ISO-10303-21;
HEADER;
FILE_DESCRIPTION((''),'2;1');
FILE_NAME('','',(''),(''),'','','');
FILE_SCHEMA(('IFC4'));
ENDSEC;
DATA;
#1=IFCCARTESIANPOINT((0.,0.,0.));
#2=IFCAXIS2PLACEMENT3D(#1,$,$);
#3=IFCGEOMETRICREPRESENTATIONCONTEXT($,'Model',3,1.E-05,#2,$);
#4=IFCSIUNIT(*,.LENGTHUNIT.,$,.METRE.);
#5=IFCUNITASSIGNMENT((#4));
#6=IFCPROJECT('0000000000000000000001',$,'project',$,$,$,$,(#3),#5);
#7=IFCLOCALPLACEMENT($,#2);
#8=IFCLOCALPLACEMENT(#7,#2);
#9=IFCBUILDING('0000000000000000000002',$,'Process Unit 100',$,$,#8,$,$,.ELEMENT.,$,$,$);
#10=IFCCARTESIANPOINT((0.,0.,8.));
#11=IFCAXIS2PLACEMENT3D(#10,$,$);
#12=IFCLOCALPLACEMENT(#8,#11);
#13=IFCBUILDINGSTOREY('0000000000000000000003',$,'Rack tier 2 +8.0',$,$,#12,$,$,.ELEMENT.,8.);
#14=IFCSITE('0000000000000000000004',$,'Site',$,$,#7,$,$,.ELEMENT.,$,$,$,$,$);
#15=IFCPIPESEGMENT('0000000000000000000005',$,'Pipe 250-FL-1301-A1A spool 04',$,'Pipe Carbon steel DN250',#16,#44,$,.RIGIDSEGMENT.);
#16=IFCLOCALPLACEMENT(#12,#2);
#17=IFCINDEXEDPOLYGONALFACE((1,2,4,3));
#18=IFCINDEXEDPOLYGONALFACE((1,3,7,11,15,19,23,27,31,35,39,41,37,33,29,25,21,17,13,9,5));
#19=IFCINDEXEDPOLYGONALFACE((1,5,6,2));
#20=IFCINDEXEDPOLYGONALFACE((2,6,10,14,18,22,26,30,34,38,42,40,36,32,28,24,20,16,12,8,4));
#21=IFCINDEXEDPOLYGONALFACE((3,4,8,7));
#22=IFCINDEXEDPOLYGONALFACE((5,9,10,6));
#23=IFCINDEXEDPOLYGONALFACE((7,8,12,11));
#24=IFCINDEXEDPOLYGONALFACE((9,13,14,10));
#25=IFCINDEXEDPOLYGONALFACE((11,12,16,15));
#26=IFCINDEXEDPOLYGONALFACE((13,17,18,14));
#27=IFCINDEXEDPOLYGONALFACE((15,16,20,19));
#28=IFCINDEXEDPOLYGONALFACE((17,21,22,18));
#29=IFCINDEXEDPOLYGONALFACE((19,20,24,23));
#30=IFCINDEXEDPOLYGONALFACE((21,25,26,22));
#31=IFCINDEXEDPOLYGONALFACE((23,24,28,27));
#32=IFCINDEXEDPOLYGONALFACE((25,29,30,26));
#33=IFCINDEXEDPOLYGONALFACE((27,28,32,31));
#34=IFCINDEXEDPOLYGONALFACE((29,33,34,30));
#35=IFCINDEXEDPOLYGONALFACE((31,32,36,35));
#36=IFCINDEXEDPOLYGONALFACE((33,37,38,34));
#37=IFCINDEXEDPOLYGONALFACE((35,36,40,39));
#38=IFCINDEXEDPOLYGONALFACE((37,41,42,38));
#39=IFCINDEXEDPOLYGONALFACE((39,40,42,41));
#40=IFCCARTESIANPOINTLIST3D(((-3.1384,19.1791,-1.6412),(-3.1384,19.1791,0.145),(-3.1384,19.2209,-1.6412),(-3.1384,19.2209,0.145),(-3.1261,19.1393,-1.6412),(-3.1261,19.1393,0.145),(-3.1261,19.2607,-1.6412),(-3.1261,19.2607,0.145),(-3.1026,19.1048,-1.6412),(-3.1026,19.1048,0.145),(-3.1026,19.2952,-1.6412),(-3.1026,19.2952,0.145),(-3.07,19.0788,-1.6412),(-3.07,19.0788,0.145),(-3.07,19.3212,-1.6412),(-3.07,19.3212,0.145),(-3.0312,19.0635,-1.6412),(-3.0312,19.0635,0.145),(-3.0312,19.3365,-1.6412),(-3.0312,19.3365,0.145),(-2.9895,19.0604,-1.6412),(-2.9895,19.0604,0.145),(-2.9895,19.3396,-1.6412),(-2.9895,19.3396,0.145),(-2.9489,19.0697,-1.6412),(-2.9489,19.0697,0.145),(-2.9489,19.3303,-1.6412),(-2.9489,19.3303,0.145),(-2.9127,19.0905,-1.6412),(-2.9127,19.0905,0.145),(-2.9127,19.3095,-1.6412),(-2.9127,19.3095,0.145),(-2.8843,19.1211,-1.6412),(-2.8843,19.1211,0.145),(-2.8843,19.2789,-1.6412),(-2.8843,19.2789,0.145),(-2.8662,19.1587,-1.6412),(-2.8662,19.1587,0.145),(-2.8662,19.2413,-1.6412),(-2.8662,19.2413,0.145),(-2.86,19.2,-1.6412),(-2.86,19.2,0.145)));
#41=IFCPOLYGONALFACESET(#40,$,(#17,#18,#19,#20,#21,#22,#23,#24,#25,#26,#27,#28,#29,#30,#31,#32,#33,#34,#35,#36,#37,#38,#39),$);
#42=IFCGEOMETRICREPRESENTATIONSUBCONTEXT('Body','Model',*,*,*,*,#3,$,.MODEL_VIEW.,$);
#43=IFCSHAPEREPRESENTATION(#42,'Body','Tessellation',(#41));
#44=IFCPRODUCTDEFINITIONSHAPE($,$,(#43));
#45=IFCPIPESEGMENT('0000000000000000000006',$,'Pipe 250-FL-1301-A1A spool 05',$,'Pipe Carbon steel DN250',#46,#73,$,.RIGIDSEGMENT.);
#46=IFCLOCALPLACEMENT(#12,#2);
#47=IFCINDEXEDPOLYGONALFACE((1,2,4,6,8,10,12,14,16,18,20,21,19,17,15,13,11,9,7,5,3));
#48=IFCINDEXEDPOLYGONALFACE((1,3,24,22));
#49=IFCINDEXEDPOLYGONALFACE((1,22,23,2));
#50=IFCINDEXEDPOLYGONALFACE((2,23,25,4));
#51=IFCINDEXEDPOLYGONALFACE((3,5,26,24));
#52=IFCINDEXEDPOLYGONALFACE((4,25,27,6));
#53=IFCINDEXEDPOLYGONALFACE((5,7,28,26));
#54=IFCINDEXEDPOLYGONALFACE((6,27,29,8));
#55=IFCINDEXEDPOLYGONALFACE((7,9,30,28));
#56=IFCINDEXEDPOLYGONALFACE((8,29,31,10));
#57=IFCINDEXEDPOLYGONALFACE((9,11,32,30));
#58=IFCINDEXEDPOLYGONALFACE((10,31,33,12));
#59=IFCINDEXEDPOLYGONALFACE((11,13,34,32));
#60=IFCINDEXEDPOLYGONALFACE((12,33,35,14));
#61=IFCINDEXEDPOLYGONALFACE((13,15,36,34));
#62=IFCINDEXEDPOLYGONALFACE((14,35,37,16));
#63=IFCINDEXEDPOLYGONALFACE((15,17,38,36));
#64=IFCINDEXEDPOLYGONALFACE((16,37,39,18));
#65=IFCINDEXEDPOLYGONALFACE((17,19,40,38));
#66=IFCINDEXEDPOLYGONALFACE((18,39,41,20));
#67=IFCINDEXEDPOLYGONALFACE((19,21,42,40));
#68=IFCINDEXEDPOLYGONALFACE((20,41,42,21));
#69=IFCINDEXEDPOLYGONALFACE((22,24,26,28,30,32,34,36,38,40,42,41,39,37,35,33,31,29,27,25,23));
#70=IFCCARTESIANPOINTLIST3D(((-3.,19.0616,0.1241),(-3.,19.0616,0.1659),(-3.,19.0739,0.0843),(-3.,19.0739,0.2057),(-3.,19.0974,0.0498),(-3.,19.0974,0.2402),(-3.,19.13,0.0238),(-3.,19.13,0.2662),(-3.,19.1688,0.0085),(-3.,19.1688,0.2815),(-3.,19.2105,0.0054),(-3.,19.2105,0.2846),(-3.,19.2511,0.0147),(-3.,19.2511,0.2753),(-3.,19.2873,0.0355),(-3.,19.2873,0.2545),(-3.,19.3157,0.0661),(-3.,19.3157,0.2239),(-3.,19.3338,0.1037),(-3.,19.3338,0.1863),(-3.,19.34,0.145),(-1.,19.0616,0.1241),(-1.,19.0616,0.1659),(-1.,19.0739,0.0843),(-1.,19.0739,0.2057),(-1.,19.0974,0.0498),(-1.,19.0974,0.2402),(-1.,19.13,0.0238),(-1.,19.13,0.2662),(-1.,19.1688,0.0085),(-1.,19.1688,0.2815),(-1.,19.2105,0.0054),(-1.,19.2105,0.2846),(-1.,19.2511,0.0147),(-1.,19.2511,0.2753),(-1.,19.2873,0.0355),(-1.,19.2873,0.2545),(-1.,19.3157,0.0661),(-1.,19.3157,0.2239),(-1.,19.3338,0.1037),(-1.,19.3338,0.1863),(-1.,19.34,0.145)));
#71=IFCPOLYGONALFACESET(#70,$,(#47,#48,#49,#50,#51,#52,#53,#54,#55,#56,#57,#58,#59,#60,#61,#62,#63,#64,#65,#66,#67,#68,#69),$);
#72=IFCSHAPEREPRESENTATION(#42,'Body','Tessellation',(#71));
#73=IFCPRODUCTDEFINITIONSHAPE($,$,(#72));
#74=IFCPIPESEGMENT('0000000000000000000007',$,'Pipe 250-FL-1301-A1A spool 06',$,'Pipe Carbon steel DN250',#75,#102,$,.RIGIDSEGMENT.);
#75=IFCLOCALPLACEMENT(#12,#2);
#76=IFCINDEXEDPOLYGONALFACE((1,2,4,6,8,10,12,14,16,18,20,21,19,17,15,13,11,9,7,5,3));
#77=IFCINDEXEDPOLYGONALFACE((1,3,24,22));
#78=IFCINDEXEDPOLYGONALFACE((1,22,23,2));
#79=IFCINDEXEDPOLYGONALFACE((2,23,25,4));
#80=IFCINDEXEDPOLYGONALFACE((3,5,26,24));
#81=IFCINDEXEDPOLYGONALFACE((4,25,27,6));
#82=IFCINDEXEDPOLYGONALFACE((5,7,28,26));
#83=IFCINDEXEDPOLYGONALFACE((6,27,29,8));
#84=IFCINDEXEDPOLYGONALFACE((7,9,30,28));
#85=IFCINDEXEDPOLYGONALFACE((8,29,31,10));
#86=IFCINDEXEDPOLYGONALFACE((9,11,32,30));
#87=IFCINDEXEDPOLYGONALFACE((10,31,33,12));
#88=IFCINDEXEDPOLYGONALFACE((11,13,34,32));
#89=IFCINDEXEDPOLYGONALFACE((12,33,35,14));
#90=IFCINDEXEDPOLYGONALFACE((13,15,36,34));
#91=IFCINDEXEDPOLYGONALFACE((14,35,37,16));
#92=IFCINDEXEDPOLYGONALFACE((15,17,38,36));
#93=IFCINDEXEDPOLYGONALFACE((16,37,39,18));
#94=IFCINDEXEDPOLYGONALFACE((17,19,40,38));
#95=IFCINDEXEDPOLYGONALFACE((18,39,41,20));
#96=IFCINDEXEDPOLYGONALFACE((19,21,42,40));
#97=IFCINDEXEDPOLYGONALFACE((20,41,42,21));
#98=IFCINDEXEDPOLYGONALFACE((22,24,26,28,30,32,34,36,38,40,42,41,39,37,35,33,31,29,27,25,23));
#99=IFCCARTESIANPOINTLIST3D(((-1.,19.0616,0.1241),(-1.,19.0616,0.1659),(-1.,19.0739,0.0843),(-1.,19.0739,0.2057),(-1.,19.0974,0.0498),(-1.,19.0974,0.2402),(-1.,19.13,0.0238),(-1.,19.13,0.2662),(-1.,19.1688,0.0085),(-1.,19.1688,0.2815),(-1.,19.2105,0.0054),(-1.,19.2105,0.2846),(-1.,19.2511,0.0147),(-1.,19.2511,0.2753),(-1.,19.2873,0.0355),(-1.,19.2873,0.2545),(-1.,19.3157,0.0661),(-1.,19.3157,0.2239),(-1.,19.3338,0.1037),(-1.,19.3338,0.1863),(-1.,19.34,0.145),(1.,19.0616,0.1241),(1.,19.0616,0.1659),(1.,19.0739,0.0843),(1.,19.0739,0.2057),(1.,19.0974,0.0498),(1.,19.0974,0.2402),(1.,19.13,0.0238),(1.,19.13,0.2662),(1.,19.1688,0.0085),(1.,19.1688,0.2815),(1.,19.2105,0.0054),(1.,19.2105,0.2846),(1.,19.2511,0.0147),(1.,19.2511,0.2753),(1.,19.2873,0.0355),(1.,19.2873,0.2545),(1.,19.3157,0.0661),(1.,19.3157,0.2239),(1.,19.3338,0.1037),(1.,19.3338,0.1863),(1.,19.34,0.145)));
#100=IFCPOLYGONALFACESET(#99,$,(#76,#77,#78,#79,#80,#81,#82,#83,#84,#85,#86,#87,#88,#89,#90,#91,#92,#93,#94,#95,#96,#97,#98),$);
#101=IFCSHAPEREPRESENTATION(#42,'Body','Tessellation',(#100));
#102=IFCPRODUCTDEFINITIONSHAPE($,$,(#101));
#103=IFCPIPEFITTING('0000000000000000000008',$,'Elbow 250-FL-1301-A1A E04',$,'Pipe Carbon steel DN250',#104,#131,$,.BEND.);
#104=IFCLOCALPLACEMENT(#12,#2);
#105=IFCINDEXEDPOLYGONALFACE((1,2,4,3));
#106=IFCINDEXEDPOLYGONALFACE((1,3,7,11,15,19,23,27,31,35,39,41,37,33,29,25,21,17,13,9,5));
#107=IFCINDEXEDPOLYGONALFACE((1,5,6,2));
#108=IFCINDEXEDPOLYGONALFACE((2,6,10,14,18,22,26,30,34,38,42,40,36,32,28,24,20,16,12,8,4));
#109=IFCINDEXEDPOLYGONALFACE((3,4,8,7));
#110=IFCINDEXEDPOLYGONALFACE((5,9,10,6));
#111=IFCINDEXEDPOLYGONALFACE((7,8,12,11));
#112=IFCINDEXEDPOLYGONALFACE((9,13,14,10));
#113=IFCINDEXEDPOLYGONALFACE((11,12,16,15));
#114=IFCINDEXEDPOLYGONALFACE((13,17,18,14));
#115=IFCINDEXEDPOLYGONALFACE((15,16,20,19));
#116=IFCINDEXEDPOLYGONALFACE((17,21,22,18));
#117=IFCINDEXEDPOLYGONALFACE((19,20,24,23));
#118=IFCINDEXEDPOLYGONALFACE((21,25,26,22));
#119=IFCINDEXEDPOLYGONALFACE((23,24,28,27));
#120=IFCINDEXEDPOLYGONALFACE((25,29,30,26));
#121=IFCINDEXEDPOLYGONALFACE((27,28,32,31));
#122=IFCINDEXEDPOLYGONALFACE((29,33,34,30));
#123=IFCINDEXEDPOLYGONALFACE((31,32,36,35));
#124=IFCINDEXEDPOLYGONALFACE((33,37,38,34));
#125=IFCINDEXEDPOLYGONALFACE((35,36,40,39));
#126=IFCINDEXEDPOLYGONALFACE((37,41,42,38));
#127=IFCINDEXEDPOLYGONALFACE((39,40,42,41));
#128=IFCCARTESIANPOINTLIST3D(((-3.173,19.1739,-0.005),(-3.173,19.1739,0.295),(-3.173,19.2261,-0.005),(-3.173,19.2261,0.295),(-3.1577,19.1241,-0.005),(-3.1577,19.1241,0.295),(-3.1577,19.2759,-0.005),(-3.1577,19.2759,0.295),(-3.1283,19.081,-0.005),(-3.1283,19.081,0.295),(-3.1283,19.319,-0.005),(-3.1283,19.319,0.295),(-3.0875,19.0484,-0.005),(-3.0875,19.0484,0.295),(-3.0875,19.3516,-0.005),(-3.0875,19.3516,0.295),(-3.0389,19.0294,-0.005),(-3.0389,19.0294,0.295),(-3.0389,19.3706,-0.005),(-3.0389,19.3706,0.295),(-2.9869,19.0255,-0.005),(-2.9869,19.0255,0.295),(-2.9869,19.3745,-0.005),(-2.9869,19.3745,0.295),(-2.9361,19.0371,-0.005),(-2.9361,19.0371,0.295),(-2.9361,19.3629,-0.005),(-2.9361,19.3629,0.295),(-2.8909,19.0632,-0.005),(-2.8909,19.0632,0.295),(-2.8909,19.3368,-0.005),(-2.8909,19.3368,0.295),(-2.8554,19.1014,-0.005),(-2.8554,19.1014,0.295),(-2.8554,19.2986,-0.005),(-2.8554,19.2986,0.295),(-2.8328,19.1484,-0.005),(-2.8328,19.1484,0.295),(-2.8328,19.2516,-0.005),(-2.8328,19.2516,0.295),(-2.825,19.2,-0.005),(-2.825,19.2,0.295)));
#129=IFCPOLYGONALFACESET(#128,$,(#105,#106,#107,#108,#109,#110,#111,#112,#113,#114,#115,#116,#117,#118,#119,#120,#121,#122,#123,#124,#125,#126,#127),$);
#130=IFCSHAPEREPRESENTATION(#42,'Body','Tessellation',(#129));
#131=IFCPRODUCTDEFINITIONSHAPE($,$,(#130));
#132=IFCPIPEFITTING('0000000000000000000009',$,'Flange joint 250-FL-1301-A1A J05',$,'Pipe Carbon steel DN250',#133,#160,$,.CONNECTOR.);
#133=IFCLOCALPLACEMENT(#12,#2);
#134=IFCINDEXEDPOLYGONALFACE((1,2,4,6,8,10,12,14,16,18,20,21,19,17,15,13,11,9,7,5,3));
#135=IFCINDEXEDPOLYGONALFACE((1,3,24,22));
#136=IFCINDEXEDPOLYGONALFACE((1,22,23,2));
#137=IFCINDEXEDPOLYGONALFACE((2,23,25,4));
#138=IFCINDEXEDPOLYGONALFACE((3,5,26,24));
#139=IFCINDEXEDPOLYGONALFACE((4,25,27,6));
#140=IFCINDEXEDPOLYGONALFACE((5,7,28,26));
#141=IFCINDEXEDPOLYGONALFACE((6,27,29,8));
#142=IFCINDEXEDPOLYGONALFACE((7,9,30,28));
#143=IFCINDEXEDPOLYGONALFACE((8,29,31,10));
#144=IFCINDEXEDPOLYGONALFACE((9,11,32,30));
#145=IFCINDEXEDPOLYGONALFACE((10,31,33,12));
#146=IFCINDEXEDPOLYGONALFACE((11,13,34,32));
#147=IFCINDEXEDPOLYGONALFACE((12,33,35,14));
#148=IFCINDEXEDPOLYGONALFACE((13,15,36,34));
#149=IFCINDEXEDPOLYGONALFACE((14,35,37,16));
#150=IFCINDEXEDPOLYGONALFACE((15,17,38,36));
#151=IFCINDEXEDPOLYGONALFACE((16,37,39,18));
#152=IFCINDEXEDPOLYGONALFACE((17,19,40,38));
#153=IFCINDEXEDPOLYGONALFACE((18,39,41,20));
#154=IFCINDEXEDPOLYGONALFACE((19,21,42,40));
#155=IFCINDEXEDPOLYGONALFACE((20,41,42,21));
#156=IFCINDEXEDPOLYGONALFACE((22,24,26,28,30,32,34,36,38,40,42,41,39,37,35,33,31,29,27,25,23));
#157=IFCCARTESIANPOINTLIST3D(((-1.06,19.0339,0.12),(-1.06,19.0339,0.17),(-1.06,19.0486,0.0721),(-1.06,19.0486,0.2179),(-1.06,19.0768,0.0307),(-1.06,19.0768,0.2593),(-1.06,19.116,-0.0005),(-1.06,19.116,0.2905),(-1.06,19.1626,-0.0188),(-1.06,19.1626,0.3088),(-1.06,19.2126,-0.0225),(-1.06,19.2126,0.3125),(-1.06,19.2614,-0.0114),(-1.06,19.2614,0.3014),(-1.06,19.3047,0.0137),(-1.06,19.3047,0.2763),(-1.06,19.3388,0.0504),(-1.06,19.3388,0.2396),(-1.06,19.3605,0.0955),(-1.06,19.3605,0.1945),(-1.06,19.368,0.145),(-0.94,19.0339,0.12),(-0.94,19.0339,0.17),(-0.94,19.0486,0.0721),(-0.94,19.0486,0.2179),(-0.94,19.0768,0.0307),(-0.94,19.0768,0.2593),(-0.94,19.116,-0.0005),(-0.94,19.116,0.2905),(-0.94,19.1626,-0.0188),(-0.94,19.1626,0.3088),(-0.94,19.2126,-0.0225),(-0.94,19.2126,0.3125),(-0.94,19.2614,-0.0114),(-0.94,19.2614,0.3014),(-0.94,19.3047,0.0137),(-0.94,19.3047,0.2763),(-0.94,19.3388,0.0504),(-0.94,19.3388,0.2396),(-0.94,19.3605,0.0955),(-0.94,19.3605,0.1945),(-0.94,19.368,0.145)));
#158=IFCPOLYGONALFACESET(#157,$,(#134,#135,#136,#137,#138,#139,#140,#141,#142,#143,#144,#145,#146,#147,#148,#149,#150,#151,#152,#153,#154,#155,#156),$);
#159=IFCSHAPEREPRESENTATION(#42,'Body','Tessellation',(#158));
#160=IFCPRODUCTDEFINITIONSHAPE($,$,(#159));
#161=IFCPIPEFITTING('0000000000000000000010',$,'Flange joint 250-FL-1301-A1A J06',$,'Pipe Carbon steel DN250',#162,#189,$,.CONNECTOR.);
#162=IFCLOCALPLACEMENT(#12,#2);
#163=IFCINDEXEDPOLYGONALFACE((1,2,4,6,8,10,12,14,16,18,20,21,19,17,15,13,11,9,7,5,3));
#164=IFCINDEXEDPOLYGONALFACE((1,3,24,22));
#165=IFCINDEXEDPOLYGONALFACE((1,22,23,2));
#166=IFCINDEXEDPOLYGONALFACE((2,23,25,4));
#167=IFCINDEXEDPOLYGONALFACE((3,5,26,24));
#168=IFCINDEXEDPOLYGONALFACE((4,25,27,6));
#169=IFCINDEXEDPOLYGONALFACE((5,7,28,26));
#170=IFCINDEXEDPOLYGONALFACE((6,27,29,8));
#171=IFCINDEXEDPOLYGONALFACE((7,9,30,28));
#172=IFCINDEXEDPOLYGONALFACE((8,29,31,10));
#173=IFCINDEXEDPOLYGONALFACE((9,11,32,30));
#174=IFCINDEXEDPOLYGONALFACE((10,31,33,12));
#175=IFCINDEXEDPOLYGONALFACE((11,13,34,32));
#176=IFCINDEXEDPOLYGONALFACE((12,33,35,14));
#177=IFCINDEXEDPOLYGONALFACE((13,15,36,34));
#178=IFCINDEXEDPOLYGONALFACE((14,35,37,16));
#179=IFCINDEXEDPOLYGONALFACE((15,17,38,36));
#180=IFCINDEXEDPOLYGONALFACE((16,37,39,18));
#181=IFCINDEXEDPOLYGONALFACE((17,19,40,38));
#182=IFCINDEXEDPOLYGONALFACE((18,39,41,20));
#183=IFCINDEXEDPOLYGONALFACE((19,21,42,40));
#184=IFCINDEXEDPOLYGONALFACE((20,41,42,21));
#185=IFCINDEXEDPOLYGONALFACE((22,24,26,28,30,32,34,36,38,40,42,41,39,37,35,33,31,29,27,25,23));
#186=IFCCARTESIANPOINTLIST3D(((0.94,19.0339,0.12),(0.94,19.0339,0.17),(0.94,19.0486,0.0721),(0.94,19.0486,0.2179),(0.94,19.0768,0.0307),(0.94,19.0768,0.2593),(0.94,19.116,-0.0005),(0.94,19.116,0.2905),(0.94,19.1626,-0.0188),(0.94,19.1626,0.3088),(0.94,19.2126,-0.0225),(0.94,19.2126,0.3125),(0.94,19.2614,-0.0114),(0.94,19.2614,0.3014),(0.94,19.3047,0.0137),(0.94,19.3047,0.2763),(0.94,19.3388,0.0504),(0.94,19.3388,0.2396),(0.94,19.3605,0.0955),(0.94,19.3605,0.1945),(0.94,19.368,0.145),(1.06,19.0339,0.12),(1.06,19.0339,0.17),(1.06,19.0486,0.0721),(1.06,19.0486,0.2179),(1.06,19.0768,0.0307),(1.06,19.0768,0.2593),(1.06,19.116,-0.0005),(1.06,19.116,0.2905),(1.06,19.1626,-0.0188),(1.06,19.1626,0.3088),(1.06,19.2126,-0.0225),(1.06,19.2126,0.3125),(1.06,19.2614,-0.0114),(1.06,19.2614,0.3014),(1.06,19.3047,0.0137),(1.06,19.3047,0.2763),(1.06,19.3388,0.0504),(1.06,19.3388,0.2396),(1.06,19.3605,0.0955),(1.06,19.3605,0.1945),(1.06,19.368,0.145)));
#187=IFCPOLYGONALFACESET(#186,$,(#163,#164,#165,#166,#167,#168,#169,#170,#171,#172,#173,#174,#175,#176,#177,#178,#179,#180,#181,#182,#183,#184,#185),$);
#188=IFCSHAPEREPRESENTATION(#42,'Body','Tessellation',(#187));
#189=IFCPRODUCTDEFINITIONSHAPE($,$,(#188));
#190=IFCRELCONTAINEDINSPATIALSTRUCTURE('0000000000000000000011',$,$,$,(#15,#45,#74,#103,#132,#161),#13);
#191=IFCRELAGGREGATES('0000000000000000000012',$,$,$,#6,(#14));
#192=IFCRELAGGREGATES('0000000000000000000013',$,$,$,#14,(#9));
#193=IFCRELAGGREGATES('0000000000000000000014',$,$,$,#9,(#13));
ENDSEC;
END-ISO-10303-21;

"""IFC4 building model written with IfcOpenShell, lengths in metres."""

from ifc_helpers import new_model, si_unit, frame, origin, place, context, subcontext, project, spatial, circle, extrude, element, save


model = new_model("IFC4")

# Units and contexts
model_context = context("Model", 3, precision=1e-05, world=origin())
body_context = subcontext(model_context, "Body", "Model", "MODEL_VIEW")
ifc_project = project(units=[si_unit("LENGTHUNIT", "METRE")], contexts=[model_context])

# Site, building, storey
site_placement = place(None, origin())
site = spatial("IfcSite", under=ifc_project, at=site_placement, Name="Site", CompositionType="ELEMENT")
building_placement = place(site_placement, origin())
building = spatial("IfcBuilding", under=site, at=building_placement, Name="Process Unit 100", CompositionType="ELEMENT")
storey_placement = place(building_placement, frame((0.0, 0.0, 8.0)))
storey = spatial("IfcBuildingStorey", under=building, at=storey_placement, Name="Rack tier 2 +8.0", CompositionType="ELEMENT", Elevation=8.0)

# Pipe segments
pipe_segment_1_placement = place(storey_placement, frame((-3.0, 19.2, -1.6412), z_axis=(0.0, 0.0, 1.0), x_axis=(1.0, 0.0, 0.0)))
element("IfcPipeSegment", 1, at=pipe_segment_1_placement, inside=storey, Name="Pipe 250-FL-1301-A1A spool 04", ObjectType="Pipe Carbon steel DN250", PredefinedType="RIGIDSEGMENT", context=body_context, shape_type="SweptSolid", body=[
    extrude(circle(Radius=0.14), origin(), (0.0, 0.0, 1.0), 1.7863),
])
for number, where, z_axis, x_axis, name in (
    (2, (-3.0, 19.2, 0.145), (1.0, 0.0, 0.0), (0.0, 1.0, 0.0), "Pipe 250-FL-1301-A1A spool 05"),
    (3, (-1.0, 19.2, 0.145), (1.0, 0.0, 0.0), (0.0, 1.0, 0.0), "Pipe 250-FL-1301-A1A spool 06"),
):
    element("IfcPipeSegment", number, at=place(storey_placement, frame(where, z_axis=z_axis, x_axis=x_axis)), inside=storey, Name=name, ObjectType="Pipe Carbon steel DN250", PredefinedType="RIGIDSEGMENT", context=body_context, shape_type="SweptSolid", body=[
        extrude(circle(Radius=0.14), origin(), (0.0, 0.0, 1.0), 2.0),
    ])

# Pipe fittings
pipe_fitting_1_placement = place(storey_placement, frame((-3.0, 19.2, -0.005), z_axis=(0.0, 0.0, 1.0), x_axis=(1.0, 0.0, 0.0)))
element("IfcPipeFitting", 4, at=pipe_fitting_1_placement, inside=storey, Name="Elbow 250-FL-1301-A1A E04", ObjectType="Pipe Carbon steel DN250", PredefinedType="BEND", context=body_context, shape_type="SweptSolid", body=[
    extrude(circle(Radius=0.175), origin(), (0.0, 0.0, 1.0), 0.3),
])
for number, where, z_axis, x_axis, name in (
    (5, (-1.06, 19.2, 0.145), (1.0, 0.0, 0.0), (0.0, 1.0, 0.0), "Flange joint 250-FL-1301-A1A J05"),
    (6, (0.94, 19.2, 0.145), (1.0, 0.0, 0.0), (0.0, 1.0, 0.0), "Flange joint 250-FL-1301-A1A J06"),
):
    element("IfcPipeFitting", number, at=place(storey_placement, frame(where, z_axis=z_axis, x_axis=x_axis)), inside=storey, Name=name, ObjectType="Pipe Carbon steel DN250", PredefinedType="CONNECTOR", context=body_context, shape_type="SweptSolid", body=[
        extrude(circle(Radius=0.168), origin(), (0.0, 0.0, 1.0), 0.12),
    ])

save(model, "model.ifc")
